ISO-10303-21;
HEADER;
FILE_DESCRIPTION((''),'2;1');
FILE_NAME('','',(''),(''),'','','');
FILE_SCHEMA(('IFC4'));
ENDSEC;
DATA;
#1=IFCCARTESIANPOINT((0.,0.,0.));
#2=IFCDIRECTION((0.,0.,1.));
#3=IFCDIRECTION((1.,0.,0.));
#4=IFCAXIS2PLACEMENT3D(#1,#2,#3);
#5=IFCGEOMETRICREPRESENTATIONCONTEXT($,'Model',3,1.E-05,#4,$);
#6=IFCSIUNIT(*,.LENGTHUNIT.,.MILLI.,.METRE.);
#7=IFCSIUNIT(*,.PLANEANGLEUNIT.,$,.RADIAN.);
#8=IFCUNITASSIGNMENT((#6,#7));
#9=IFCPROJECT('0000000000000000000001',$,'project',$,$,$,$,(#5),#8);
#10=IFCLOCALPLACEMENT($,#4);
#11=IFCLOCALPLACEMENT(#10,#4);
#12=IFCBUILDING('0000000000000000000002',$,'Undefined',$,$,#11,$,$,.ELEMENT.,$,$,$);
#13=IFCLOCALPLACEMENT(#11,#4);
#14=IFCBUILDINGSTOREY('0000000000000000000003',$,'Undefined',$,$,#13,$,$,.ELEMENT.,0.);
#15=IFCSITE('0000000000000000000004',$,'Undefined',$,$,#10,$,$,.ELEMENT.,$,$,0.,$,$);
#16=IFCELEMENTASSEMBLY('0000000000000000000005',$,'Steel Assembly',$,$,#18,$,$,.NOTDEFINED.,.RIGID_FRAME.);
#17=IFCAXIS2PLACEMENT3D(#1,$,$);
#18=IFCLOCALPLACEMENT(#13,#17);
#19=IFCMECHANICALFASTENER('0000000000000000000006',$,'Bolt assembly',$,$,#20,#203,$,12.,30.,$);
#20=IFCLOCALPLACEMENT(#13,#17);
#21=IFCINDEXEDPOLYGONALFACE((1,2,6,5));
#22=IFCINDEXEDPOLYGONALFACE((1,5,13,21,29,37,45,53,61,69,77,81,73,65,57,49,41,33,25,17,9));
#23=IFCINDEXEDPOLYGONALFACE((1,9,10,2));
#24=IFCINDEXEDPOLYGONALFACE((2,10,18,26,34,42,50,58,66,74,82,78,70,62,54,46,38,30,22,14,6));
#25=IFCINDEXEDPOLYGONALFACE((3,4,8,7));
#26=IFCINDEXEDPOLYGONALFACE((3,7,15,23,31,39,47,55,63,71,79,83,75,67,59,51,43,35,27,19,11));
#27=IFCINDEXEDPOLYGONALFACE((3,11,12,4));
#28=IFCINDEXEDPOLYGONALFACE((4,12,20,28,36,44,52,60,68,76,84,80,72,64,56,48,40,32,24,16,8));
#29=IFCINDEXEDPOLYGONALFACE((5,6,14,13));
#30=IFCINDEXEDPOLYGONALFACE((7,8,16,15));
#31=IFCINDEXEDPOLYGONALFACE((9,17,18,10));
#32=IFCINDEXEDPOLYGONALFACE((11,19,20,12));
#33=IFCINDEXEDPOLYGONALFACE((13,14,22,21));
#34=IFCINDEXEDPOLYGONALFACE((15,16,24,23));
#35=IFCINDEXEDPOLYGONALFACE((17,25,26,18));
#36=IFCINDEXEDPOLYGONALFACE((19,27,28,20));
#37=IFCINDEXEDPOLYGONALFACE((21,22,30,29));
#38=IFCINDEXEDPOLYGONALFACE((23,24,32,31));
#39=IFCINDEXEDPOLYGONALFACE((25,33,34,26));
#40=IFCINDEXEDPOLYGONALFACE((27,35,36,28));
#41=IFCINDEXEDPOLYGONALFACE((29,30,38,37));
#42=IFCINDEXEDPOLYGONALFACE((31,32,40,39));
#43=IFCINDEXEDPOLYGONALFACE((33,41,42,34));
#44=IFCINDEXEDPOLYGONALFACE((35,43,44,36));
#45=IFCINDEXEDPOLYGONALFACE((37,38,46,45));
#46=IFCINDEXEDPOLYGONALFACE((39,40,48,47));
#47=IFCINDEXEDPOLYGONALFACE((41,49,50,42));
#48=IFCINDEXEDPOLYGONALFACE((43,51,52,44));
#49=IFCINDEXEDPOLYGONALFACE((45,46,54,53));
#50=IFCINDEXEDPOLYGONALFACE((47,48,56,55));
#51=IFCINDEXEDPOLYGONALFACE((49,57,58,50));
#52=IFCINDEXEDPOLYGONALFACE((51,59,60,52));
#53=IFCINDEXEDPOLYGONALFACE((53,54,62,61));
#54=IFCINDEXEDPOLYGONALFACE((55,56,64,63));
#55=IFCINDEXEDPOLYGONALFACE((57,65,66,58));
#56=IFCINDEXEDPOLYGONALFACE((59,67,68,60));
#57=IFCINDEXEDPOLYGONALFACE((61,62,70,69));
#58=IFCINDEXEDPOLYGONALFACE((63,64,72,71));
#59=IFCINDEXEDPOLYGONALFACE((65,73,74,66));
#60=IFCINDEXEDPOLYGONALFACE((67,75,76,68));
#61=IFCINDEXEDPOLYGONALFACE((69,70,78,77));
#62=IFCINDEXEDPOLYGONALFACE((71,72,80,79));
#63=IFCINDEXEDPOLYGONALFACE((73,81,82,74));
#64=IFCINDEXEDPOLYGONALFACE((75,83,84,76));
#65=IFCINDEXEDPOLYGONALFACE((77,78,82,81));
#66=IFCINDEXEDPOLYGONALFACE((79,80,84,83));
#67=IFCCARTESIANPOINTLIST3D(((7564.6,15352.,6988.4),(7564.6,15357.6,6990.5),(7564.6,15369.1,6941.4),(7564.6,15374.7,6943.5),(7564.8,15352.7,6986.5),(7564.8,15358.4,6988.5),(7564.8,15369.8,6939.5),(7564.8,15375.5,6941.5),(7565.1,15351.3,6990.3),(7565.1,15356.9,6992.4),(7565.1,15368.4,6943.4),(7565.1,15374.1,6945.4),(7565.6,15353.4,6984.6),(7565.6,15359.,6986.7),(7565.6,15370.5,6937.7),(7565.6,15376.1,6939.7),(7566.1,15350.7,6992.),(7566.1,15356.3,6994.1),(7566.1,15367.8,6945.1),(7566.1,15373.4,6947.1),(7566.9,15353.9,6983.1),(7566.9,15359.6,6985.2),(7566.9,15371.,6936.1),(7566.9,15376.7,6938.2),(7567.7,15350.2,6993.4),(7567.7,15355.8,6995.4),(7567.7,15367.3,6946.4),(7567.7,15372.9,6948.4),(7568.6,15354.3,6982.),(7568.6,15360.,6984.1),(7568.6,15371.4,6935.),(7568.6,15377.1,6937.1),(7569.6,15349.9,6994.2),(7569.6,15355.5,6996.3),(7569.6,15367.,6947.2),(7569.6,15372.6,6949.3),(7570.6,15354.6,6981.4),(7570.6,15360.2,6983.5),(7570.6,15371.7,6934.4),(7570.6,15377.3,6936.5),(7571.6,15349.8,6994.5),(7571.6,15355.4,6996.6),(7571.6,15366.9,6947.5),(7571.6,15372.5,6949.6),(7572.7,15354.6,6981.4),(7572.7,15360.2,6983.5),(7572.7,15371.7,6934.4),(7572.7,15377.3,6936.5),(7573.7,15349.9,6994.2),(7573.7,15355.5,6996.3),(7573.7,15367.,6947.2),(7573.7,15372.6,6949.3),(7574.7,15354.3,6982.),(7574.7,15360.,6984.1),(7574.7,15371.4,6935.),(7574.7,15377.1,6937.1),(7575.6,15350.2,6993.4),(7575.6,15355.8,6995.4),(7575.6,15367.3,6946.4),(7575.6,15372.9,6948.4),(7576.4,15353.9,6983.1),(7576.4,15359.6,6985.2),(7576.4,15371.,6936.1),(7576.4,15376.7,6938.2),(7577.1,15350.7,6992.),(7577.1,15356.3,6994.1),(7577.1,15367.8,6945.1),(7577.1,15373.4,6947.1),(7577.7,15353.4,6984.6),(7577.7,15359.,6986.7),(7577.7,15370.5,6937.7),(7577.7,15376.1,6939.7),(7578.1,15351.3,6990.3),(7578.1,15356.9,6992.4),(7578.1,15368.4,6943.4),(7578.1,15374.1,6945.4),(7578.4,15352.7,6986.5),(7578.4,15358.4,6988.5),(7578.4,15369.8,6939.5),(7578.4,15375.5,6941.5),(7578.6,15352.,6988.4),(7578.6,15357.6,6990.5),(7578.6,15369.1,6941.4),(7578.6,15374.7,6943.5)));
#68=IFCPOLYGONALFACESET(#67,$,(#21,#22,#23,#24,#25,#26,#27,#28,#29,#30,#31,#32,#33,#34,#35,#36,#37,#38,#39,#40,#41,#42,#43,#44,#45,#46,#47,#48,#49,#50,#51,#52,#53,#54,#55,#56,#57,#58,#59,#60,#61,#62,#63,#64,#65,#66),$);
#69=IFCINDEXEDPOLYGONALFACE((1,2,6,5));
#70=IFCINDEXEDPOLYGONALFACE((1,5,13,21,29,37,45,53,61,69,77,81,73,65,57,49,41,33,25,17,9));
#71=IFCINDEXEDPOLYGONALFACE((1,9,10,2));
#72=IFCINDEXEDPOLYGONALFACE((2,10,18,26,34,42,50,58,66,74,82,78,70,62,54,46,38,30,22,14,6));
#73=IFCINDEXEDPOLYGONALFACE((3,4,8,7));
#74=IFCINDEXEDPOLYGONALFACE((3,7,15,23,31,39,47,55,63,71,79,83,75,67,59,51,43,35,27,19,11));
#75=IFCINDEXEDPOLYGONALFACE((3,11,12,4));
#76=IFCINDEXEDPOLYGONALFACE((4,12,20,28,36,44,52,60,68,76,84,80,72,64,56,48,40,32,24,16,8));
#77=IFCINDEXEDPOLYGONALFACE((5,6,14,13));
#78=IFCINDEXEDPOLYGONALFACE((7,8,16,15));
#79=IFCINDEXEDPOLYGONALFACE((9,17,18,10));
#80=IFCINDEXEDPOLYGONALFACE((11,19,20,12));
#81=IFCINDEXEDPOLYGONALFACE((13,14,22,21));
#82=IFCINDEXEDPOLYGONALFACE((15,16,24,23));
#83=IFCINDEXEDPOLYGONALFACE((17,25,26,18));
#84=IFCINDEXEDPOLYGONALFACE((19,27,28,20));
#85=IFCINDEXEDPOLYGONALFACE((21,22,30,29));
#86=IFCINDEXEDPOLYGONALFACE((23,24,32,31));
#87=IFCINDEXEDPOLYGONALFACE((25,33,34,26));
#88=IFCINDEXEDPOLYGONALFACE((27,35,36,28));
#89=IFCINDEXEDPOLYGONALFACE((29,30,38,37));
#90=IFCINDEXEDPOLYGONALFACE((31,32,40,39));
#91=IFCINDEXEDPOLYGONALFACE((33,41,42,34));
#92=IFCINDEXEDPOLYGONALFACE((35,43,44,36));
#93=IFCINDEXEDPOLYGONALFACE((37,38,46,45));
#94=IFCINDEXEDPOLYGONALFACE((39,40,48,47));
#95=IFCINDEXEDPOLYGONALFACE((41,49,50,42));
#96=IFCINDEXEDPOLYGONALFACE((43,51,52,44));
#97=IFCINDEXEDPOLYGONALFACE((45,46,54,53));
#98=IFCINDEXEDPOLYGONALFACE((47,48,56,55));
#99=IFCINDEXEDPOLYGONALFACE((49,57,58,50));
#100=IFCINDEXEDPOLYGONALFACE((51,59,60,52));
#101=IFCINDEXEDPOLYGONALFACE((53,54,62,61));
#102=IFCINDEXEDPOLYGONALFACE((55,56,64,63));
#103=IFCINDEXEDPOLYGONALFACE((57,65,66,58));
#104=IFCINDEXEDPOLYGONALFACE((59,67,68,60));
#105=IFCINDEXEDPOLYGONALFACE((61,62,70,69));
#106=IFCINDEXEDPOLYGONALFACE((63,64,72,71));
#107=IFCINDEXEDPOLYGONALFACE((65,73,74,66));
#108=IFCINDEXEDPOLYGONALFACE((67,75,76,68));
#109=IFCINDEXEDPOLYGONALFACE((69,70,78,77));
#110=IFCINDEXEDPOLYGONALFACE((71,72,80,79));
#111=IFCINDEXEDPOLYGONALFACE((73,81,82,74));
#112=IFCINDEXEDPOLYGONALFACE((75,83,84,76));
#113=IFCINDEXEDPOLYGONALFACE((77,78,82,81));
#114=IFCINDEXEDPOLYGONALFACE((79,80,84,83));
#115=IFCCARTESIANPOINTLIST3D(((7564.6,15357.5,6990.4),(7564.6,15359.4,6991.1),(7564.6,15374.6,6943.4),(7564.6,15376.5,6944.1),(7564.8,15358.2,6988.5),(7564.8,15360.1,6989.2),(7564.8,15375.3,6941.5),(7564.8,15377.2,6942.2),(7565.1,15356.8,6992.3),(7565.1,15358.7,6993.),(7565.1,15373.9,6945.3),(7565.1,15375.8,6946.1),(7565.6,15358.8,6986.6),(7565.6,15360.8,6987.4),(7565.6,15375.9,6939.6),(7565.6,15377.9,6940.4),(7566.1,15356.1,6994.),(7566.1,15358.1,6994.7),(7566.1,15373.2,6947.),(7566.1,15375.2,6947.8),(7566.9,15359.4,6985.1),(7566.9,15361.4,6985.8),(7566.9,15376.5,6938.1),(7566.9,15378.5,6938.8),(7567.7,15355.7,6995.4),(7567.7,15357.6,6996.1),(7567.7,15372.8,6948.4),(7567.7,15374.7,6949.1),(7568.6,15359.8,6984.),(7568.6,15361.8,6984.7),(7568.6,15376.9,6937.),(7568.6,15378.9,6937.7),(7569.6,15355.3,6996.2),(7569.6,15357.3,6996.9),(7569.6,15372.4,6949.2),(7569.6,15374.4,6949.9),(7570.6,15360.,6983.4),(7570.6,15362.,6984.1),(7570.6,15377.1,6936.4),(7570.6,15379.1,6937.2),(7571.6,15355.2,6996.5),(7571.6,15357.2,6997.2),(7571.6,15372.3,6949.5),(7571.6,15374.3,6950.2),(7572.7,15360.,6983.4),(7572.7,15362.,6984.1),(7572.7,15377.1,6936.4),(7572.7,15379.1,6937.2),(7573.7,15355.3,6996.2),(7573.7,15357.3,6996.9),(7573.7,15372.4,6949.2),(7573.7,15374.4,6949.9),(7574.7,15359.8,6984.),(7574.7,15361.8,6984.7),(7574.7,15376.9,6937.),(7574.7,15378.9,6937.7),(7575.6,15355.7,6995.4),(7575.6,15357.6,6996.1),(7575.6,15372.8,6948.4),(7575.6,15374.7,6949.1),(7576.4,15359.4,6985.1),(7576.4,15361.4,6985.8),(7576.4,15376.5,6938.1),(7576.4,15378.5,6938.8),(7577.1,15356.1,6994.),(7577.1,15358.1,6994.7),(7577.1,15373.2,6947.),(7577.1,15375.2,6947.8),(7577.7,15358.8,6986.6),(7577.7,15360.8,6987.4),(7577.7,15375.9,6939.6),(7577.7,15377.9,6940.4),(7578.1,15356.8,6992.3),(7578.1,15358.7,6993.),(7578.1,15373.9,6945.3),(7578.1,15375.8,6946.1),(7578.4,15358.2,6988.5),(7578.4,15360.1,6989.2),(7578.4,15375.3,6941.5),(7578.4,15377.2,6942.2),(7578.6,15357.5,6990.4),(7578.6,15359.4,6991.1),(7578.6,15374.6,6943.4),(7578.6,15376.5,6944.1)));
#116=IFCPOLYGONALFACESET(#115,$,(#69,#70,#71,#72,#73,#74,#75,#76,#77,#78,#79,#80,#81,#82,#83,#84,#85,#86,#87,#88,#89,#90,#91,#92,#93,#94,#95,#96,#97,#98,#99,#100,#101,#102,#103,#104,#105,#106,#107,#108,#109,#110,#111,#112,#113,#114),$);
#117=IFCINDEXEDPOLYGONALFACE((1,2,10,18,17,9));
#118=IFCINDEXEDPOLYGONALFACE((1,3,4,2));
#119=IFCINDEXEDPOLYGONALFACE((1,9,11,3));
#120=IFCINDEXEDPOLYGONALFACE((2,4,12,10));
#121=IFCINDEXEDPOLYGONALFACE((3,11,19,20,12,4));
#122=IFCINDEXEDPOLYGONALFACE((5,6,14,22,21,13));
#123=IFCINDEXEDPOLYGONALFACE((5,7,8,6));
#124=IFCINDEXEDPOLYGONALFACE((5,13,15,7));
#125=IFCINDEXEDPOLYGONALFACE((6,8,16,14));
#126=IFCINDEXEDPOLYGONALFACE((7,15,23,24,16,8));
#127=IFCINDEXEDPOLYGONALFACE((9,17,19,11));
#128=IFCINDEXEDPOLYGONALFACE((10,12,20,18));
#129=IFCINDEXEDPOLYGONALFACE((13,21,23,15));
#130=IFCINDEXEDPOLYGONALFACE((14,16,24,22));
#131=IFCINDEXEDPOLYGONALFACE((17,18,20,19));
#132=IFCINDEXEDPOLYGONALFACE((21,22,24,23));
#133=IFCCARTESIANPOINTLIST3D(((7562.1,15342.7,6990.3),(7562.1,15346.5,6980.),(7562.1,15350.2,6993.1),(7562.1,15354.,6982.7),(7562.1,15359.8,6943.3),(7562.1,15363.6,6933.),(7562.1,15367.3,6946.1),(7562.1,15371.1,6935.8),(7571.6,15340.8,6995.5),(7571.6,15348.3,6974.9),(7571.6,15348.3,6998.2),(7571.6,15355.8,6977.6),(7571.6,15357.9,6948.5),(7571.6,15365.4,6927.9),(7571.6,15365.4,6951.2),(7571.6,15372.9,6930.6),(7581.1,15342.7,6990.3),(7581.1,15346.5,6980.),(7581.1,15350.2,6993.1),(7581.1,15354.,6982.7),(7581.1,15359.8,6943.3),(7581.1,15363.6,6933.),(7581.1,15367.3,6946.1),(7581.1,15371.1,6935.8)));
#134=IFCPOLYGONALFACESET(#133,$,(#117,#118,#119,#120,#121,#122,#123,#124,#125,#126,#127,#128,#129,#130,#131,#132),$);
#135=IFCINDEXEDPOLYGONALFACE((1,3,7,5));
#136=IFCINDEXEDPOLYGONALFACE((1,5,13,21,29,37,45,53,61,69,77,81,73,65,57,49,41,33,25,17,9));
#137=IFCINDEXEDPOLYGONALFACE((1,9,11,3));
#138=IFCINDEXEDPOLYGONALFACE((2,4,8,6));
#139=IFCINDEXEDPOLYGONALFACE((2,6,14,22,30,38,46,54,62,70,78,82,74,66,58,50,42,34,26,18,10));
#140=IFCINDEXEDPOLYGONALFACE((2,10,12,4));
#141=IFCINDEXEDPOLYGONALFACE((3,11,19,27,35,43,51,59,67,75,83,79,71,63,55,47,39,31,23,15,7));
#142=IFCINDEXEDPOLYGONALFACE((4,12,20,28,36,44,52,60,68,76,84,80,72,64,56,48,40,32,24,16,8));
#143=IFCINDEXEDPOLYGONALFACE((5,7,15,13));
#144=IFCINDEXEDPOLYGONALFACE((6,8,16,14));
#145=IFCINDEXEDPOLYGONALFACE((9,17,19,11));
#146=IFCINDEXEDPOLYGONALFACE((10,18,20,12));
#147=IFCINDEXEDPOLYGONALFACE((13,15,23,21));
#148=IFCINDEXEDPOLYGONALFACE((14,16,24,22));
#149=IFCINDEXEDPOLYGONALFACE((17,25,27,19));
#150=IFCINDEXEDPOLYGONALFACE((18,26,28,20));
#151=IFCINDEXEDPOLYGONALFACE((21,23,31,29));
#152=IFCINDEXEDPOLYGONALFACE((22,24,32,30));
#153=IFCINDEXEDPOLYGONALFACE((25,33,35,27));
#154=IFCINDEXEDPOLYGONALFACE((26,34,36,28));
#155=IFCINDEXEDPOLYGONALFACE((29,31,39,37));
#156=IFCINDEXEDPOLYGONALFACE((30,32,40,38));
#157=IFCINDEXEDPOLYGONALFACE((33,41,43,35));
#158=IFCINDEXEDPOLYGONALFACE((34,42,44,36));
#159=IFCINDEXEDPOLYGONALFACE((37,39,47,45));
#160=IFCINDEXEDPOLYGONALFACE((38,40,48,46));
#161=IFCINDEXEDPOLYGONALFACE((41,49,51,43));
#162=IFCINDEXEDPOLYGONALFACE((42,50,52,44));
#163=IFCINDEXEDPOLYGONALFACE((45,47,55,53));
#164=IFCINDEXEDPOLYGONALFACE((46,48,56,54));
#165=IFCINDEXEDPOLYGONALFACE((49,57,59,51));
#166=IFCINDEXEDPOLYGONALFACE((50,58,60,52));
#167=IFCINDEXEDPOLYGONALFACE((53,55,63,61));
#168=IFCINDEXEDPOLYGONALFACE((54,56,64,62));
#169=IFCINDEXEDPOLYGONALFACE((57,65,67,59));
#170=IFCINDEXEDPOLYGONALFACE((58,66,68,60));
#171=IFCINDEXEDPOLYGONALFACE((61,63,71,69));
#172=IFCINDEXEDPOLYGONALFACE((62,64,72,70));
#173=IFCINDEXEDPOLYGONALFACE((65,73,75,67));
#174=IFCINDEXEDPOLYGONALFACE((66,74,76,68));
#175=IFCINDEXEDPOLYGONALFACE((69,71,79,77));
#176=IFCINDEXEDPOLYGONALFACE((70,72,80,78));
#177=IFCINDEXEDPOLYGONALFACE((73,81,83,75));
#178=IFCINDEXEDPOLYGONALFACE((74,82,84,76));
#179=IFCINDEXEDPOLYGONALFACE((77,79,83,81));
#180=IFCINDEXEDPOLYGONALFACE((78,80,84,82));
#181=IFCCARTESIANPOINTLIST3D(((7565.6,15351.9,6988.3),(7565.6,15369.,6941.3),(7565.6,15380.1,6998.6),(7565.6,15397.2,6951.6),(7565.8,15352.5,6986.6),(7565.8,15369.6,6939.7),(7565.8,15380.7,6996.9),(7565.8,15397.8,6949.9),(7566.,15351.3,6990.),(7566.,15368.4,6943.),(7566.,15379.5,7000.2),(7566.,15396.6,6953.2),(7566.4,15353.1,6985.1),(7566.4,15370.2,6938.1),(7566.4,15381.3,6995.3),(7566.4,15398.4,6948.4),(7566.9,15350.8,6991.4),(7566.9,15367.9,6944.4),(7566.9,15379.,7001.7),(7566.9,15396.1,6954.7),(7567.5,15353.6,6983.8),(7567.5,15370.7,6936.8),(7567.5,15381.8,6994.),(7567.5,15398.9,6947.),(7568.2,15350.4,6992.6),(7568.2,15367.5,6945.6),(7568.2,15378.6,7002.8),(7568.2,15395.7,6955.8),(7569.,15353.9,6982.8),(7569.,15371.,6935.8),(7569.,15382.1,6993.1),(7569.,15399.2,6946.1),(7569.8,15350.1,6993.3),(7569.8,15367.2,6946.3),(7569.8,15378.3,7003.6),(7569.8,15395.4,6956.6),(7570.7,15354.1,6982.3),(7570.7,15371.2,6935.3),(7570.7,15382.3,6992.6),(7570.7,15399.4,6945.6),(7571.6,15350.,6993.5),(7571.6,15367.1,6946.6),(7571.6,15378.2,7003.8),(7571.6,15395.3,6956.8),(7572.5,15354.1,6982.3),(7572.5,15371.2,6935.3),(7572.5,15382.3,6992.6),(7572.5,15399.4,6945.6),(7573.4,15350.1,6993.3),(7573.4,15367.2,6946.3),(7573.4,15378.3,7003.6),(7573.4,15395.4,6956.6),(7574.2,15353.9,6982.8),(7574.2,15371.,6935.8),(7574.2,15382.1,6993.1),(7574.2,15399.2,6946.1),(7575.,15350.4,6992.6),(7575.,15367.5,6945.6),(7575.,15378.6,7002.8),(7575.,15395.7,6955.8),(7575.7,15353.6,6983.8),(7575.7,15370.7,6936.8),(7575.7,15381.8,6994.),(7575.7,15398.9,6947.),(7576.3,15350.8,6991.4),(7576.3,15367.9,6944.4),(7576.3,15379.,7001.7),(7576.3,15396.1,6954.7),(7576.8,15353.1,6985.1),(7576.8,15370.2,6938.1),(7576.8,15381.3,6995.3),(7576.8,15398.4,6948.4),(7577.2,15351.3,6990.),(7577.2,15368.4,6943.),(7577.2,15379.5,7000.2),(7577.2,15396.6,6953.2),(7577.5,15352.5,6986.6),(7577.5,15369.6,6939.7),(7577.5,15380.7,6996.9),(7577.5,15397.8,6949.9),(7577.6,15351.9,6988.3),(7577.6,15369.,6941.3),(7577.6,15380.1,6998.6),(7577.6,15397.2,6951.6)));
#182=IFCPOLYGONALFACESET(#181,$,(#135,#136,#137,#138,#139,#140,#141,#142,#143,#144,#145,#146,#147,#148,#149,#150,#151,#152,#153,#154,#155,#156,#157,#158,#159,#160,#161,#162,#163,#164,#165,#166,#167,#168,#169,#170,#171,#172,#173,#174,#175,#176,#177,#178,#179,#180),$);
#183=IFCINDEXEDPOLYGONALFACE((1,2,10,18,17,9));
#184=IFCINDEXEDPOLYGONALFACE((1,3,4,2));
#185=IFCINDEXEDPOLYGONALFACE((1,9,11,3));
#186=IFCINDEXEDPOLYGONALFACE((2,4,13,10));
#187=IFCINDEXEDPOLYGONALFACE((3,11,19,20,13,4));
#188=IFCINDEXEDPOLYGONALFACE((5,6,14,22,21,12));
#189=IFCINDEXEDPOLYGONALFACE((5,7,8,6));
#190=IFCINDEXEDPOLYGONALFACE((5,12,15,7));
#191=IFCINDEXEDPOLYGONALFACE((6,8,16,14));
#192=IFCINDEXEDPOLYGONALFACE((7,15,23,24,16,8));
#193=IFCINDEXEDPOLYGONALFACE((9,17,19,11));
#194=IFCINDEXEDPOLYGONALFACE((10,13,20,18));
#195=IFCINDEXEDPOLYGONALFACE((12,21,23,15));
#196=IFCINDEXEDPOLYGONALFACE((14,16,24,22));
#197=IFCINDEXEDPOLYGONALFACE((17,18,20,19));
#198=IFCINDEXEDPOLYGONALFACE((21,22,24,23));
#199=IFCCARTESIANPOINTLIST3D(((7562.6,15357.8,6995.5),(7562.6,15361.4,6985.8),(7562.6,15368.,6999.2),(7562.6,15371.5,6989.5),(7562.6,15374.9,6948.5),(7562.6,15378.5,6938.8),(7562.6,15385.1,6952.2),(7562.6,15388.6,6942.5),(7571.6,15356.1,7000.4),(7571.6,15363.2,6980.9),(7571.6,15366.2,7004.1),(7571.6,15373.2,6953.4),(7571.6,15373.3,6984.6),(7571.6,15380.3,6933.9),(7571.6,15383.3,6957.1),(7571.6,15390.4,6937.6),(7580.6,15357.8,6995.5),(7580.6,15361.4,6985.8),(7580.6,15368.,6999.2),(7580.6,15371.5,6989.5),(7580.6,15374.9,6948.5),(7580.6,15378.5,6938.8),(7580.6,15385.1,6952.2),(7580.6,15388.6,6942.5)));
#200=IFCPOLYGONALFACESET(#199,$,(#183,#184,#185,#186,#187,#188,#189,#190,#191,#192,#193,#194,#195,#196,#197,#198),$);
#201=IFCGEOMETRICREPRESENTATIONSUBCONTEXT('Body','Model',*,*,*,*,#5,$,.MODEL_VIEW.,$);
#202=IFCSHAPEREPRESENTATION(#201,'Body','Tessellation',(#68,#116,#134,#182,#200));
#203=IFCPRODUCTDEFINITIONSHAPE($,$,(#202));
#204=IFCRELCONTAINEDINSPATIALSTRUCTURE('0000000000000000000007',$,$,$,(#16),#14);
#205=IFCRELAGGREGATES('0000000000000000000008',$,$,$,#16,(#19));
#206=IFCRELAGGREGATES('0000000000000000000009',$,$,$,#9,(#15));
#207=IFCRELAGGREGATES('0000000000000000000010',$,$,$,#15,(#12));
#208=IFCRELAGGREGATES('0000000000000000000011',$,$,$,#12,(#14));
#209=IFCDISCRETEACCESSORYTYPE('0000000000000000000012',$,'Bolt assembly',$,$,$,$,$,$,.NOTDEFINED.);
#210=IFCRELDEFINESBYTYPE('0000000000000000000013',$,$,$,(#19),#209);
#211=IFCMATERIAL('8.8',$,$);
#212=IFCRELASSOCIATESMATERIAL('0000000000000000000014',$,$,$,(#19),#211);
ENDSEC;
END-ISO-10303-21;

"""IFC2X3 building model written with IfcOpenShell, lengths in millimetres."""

from ifc_helpers import new_model, si_unit, frame, origin_with_axes, origin_2d_with_axis, place, context, subcontext, project, spatial, polyline, circle, outline, extrude, source, transform, mapped, material, type_object, element, aggregate, save


model = new_model("IFC2X3")

# Units and contexts
model_context = context("Model", 3, precision=1e-05, world=origin_with_axes())
body_context = subcontext(model_context, "Body", "Model", "MODEL_VIEW")
ifc_project = project(units=[si_unit("LENGTHUNIT", "METRE", prefix="MILLI"), si_unit("PLANEANGLEUNIT", "RADIAN")], contexts=[model_context])

# Site, building, storey
site_placement = place(None, origin_with_axes())
site = spatial("IfcSite", under=ifc_project, at=site_placement, Name="Undefined", CompositionType="ELEMENT", RefElevation=0.0)
building_placement = place(site_placement, origin_with_axes())
building = spatial("IfcBuilding", under=site, at=building_placement, Name="Undefined", CompositionType="ELEMENT")
storey_placement = place(building_placement, origin_with_axes())
storey = spatial("IfcBuildingStorey", under=building, at=storey_placement, Name="Undefined", CompositionType="ELEMENT", Elevation=0.0)

# Element assembly, mechanical fastener
assembly_1_placement = place(storey_placement, origin_with_axes())
assembly_1 = element("IfcElementAssembly", 1, at=assembly_1_placement, inside=storey, Name="Steel Assembly", AssemblyPlace="NOTDEFINED", PredefinedType="RIGID_FRAME")
ifc_material_1 = material(Name="8.8")
discrete_accessory_type_1 = type_object("IfcDiscreteAccessoryType", Name="Bolt assembly")
shared_shape_1 = source(origin_with_axes(), body_context, "Body", "SweptSolid", [
    extrude(circle(Radius=7.0, at=origin_2d_with_axis()), frame((0.0, -5.9, 0.0), z_axis=(0.0, 1.0, 0.0), x_axis=(1.0, 0.0, 0.0)), (0.0, 0.0, 1.0), 6.0),
    extrude(circle(Radius=7.0, at=origin_2d_with_axis()), frame((0.0, -0.1, 0.0), z_axis=(0.0, 1.0, 0.0), x_axis=(1.0, 0.0, 0.0)), (0.0, 0.0, 1.0), 2.1),
    extrude(outline(polyline([(11.0, 0.0), (5.5, 9.5), (-5.5, 9.5), (-11.0, 0.0), (-5.5, -9.5), (5.5, -9.5), (11.0, 0.0)])), frame((0.0, -14.0, 0.0), z_axis=(0.0, 1.0, 0.0), x_axis=(1.0, 0.0, 0.0)), (0.0, 0.0, 1.0), 8.0),
    extrude(circle(Radius=6.0, at=origin_2d_with_axis()), frame((0.0, -6.0, 0.0), z_axis=(0.0, 1.0, 0.0), x_axis=(1.0, 0.0, 0.0)), (0.0, 0.0, 1.0), 30.0),
    extrude(outline(polyline([(10.4, 0.0), (5.2, 9.0), (-5.2, 9.0), (-10.4, 0.0), (-5.2, -9.0), (5.2, -9.0), (10.4, 0.0)])), frame((0.0, 2.0, 0.0), z_axis=(0.0, 1.0, 0.0), x_axis=(1.0, 0.0, 0.0)), (0.0, 0.0, 1.0), 10.8),
])
mechanical_fastener_1_placement = place(assembly_1_placement, frame((7571.6, 15374.8, 6943.0), z_axis=(-1.0, 0.0, 0.0), x_axis=(0.0, -0.34202, 0.939693)))
mechanical_fastener_1 = element("IfcMechanicalFastener", 2, at=mechanical_fastener_1_placement, type_object=discrete_accessory_type_1, material=ifc_material_1, Name="Bolt assembly", NominalDiameter=12.0, NominalLength=30.0, context=body_context, shape_type="MappedRepresentation", body=[
    mapped(shared_shape_1, transform((0.0, 0.0, 0.0))),
    mapped(shared_shape_1, transform((50.0, 0.0, 0.0))),
])
aggregate(assembly_1, [mechanical_fastener_1])

save(model, "model.ifc")
